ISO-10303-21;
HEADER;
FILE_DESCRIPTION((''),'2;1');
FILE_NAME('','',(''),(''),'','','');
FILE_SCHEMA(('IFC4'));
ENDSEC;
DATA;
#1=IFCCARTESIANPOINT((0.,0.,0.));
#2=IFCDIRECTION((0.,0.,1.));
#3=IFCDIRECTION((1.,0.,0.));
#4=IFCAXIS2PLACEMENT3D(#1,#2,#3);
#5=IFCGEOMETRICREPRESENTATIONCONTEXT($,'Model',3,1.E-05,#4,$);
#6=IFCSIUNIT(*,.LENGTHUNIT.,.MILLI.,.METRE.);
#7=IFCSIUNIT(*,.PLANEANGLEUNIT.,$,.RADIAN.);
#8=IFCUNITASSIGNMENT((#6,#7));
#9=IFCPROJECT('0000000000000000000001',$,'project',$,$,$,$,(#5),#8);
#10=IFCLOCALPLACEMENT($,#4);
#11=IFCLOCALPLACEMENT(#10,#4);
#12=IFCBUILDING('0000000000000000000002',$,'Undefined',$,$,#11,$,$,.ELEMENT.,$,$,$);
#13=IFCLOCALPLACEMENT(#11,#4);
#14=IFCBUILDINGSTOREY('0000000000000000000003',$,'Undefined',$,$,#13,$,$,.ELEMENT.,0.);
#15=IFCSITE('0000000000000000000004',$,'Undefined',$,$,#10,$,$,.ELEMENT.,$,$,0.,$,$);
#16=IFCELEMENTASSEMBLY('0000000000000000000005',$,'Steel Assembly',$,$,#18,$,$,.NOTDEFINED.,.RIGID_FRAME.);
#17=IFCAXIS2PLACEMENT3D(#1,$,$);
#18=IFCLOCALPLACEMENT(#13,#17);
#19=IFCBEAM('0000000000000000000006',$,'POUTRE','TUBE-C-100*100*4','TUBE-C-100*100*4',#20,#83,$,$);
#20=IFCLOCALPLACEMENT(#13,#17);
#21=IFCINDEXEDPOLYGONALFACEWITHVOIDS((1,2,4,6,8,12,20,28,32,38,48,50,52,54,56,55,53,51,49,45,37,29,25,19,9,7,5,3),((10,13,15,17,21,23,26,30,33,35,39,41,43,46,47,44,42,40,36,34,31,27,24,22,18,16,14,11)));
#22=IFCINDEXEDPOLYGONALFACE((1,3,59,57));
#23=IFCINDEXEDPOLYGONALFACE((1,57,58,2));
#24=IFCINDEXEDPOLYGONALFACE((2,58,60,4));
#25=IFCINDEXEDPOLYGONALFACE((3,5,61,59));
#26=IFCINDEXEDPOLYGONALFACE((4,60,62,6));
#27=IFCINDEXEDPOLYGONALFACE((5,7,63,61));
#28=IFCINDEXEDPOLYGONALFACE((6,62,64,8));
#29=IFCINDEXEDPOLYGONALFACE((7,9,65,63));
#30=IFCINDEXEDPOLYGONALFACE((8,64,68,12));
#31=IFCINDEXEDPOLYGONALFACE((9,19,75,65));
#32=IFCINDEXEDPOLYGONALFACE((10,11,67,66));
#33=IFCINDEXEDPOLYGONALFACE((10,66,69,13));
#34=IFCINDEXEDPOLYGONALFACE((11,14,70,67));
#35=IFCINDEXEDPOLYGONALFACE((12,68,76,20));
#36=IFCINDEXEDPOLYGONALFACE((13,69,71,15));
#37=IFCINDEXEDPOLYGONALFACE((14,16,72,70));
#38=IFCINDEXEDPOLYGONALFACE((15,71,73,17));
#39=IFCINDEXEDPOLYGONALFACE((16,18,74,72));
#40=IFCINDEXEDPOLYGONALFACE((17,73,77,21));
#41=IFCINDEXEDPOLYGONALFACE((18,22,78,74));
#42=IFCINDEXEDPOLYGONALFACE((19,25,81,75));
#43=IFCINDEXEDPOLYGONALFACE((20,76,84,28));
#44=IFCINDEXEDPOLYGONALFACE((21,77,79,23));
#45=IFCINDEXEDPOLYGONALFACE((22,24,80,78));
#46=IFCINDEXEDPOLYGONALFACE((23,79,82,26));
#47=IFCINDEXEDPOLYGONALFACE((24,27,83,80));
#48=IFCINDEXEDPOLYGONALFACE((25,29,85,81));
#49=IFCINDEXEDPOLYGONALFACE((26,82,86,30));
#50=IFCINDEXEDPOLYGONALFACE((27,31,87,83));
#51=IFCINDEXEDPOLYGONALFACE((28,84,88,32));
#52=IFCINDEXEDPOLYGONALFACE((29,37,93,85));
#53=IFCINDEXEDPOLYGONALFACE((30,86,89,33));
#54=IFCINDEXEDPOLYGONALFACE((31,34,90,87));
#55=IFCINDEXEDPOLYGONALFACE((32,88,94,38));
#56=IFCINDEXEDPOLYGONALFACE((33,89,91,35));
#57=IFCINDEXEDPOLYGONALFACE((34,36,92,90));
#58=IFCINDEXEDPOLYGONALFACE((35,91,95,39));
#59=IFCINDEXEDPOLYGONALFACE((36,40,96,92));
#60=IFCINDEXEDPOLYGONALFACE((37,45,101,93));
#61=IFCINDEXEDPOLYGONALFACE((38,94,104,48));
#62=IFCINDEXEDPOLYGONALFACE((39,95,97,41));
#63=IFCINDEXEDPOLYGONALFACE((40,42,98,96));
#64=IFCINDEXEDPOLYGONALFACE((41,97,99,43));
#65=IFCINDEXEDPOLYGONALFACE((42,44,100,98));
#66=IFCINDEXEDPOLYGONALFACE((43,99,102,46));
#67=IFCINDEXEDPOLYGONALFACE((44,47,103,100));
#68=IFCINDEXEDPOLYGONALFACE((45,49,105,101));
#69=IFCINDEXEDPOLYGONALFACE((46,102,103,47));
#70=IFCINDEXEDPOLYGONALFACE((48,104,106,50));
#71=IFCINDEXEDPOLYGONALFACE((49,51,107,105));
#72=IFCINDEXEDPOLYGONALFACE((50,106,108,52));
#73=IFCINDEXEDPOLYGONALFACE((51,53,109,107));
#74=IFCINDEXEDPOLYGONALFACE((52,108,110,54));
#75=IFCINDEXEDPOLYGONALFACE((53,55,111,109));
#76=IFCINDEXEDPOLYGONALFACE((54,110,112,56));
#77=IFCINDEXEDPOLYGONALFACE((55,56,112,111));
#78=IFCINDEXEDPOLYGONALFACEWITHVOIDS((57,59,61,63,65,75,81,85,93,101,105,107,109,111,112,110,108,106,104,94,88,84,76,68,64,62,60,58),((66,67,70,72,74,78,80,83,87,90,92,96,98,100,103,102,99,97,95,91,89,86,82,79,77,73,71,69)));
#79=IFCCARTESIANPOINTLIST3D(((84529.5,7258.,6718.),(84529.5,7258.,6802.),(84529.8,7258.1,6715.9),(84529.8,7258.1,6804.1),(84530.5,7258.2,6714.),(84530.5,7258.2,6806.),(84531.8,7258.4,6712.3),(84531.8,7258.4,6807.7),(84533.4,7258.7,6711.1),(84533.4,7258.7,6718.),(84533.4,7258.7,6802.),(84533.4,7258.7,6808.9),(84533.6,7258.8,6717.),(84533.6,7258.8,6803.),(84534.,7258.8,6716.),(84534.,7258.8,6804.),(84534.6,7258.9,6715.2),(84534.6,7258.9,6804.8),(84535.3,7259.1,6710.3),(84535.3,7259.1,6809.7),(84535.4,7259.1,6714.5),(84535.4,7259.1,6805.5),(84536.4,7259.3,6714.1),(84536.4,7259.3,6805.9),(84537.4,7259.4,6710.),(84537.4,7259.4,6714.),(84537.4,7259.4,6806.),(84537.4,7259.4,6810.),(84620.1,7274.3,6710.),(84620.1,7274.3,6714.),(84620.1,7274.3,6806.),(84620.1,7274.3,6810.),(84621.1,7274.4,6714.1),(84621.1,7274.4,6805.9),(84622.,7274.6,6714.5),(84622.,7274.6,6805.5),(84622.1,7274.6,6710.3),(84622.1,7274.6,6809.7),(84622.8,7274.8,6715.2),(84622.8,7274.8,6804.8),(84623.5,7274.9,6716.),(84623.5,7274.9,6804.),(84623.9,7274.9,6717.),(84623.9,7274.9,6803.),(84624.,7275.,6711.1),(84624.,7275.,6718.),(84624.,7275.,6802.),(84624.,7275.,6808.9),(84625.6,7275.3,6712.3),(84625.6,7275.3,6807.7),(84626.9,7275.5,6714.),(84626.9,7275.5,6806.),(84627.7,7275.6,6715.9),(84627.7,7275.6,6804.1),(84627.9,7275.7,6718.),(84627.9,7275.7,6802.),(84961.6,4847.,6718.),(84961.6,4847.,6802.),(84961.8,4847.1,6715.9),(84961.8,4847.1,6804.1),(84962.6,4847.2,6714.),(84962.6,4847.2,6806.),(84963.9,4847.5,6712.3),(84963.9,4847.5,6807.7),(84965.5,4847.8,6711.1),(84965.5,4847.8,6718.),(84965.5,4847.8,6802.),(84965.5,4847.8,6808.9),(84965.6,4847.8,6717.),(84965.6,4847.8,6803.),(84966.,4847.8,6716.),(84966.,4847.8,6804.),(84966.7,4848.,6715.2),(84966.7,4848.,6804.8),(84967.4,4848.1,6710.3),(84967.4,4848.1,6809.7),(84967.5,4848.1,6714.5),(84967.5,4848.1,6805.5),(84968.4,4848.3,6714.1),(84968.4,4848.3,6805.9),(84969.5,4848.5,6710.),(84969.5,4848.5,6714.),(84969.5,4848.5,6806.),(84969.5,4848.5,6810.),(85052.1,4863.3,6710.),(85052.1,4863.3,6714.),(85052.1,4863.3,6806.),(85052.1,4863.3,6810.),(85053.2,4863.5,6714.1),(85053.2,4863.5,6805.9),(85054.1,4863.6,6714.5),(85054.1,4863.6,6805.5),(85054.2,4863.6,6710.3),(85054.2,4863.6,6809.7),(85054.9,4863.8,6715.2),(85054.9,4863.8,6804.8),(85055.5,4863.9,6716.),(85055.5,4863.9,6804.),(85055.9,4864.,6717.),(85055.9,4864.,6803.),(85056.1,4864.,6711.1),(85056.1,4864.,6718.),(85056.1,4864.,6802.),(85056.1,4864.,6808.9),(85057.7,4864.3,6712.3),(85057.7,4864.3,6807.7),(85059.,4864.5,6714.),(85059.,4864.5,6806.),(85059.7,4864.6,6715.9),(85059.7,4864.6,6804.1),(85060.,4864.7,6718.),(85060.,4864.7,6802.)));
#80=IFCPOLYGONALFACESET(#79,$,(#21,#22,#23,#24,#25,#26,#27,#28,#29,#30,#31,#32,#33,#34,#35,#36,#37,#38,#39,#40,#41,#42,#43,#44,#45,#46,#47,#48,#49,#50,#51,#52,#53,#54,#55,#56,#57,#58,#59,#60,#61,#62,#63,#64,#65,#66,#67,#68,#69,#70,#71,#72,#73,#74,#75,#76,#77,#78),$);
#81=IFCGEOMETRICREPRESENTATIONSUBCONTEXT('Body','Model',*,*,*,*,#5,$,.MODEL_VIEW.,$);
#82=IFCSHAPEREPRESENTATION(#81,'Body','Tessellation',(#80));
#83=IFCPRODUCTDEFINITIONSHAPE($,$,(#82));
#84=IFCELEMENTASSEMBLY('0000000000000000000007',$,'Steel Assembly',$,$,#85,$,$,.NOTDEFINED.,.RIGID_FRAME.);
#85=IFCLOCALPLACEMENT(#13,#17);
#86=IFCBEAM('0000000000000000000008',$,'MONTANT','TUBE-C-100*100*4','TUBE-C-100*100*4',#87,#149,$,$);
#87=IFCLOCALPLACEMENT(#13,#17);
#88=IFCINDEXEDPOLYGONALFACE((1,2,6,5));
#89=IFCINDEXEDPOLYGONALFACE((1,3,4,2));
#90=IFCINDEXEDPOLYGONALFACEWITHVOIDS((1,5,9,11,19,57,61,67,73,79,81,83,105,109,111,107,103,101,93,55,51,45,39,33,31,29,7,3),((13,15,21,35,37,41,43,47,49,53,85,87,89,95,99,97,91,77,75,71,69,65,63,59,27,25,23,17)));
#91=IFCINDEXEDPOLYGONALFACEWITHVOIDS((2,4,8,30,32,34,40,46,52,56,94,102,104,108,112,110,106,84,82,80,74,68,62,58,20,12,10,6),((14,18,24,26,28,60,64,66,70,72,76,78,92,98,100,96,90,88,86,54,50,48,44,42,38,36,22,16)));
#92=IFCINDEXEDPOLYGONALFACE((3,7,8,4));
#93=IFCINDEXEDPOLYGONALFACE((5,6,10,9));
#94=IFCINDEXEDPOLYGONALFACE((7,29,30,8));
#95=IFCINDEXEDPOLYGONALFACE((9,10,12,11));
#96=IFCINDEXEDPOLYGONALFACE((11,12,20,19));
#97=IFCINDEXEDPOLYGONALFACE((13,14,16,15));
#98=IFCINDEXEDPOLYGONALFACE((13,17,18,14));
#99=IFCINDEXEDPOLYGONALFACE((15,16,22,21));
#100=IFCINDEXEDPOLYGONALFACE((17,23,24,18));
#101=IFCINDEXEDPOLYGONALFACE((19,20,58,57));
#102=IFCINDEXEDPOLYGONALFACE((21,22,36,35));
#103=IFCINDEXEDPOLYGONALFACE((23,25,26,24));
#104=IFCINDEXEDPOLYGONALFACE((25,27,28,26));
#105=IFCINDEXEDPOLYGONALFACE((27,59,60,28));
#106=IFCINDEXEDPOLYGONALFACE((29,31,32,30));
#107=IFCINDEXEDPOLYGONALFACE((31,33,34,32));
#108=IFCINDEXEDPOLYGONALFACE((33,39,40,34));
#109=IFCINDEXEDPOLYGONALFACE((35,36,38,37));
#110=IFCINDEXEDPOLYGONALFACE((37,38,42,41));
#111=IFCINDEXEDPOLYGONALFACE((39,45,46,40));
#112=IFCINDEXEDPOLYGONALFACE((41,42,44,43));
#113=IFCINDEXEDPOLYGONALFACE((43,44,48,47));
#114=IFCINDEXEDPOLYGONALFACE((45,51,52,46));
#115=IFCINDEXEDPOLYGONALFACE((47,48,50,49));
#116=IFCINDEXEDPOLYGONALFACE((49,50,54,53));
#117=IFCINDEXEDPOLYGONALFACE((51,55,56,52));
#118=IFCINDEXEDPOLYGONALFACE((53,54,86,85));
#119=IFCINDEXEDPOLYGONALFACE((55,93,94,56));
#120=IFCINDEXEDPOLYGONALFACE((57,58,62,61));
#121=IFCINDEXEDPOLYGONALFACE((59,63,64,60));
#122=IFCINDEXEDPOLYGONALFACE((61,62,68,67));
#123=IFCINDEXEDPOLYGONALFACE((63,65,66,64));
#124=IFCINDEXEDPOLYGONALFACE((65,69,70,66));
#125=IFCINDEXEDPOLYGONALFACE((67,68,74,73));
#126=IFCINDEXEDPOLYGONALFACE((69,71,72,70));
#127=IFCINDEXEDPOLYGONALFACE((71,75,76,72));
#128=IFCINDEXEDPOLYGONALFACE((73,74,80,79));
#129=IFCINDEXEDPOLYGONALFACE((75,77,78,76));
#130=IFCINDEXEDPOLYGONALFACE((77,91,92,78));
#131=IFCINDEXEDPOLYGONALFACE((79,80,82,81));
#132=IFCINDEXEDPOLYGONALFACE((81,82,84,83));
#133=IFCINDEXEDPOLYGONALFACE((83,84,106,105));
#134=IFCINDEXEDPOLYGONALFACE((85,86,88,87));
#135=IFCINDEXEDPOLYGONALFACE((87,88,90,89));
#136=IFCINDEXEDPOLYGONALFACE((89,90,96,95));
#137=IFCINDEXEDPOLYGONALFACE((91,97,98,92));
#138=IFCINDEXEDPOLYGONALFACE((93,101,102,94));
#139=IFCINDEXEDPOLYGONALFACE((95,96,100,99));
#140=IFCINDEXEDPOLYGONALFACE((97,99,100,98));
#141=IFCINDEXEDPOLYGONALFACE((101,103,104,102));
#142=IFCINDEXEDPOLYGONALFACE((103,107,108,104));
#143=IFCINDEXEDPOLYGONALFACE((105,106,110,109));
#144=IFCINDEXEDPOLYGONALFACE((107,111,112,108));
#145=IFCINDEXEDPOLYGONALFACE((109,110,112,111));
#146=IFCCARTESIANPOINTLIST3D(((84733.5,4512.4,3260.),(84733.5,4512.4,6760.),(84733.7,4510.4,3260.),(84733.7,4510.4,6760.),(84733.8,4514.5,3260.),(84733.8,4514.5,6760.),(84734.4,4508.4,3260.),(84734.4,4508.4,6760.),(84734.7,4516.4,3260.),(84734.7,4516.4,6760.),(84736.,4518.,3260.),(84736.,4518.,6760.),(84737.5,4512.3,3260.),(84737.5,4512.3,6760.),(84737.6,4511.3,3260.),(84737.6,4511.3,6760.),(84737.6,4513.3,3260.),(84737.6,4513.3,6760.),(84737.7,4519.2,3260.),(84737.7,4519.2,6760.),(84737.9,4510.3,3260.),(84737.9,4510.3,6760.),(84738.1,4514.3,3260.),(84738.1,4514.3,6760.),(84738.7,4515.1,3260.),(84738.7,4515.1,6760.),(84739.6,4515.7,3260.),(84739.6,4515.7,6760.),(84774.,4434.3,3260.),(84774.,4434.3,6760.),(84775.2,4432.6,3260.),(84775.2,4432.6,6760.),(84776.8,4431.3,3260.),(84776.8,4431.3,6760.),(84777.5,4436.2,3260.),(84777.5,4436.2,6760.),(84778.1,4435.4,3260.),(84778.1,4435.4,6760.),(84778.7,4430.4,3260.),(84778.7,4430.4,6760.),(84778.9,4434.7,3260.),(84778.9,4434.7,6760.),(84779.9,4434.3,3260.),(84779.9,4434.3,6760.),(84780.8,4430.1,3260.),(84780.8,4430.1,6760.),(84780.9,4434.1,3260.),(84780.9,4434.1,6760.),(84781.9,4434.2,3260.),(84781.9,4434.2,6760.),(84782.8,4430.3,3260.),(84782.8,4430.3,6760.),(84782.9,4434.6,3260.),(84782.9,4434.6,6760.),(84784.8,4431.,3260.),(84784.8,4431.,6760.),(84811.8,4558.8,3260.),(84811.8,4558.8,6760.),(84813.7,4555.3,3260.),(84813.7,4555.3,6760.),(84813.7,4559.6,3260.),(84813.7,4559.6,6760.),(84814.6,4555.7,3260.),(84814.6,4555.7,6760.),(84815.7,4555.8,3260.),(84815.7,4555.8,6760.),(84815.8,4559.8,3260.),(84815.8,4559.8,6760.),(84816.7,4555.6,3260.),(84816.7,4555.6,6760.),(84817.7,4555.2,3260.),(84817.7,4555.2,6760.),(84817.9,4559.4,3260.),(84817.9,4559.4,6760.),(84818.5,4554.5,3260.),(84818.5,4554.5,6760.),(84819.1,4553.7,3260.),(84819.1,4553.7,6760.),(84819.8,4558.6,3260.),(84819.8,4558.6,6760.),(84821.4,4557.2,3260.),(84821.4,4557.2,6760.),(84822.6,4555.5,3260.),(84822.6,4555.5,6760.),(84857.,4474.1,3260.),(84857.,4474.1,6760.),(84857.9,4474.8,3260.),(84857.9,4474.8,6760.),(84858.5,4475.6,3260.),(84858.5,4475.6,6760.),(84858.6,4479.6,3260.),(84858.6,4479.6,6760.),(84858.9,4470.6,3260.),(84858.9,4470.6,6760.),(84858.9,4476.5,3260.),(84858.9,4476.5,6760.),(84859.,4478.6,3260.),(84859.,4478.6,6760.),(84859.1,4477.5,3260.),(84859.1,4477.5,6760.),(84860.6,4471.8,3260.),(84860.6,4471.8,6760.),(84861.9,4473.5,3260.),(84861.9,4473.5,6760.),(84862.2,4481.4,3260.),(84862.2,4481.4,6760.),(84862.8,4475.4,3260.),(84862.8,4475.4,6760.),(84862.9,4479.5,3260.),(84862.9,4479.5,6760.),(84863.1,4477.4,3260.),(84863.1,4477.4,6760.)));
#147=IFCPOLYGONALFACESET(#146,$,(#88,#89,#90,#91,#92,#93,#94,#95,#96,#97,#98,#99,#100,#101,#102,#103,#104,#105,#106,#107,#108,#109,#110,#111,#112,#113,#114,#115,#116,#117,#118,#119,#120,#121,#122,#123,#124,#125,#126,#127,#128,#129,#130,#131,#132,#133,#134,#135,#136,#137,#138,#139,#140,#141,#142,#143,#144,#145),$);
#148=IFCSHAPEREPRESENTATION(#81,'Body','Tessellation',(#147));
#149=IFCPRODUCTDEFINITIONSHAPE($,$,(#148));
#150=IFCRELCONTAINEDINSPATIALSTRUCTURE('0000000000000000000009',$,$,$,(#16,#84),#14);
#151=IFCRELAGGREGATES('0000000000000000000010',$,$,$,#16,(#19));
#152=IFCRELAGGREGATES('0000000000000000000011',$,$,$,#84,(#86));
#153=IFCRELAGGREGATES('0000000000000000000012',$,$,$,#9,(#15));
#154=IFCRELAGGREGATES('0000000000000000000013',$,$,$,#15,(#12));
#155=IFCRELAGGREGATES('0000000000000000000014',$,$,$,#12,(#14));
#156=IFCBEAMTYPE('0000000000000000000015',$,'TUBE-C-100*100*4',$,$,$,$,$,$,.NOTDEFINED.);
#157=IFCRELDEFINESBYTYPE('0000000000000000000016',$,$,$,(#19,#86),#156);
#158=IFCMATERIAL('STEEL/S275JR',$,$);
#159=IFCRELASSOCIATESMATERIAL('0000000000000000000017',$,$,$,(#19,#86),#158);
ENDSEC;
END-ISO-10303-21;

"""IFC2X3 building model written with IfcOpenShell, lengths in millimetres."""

from ifc_helpers import new_model, si_unit, frame, origin_with_axes, origin_2d_with_axis, place, context, subcontext, project, spatial, hollow_rectangle, extrude, material, type_object, element, aggregate, save


model = new_model("IFC2X3")

# Units and contexts
model_context = context("Model", 3, precision=1e-05, world=origin_with_axes())
body_context = subcontext(model_context, "Body", "Model", "MODEL_VIEW")
ifc_project = project(units=[si_unit("LENGTHUNIT", "METRE", prefix="MILLI"), si_unit("PLANEANGLEUNIT", "RADIAN")], contexts=[model_context])

# Site, building, storey
site_placement = place(None, origin_with_axes())
site = spatial("IfcSite", under=ifc_project, at=site_placement, Name="Undefined", CompositionType="ELEMENT", RefElevation=0.0)
building_placement = place(site_placement, origin_with_axes())
building = spatial("IfcBuilding", under=site, at=building_placement, Name="Undefined", CompositionType="ELEMENT")
storey_placement = place(building_placement, origin_with_axes())
storey = spatial("IfcBuildingStorey", under=building, at=storey_placement, Name="Undefined", CompositionType="ELEMENT", Elevation=0.0)

# Element assemblies, beams
ifc_material_1 = material(Name="STEEL/S275JR")
beam_type_1 = type_object("IfcBeamType", Name="TUBE-C-100*100*4", PredefinedType="NOTDEFINED")
assembly_1_placement = place(storey_placement, origin_with_axes())
assembly_1 = element("IfcElementAssembly", 1, at=assembly_1_placement, inside=storey, Name="Steel Assembly", AssemblyPlace="NOTDEFINED", PredefinedType="RIGID_FRAME")
beam_1_placement = place(assembly_1_placement, frame((85010.8, 4855.9, 6760.0), z_axis=(-0.984318, -0.176404, 0.0), x_axis=(-0.176404, 0.984318, 0.0)))
beam_1 = element("IfcBeam", 2, at=beam_1_placement, type_object=beam_type_1, material=ifc_material_1, Name="POUTRE", Description="TUBE-C-100*100*4", ObjectType="TUBE-C-100*100*4", context=body_context, shape_type="SweptSolid", body=[
    extrude(hollow_rectangle(XDim=100.0, YDim=100.0, WallThickness=4.0, InnerFilletRadius=4.0, OuterFilletRadius=8.0, at=origin_2d_with_axis()), frame((2449.4, 0.0, 0.0), z_axis=(-1.0, 0.0, 0.0), x_axis=(0.0, -1.0, 0.0)), (0.0, 0.0, 1.0), 2449.4),
])
aggregate(assembly_1, [beam_1])
assembly_2_placement = place(storey_placement, origin_with_axes())
assembly_2 = element("IfcElementAssembly", 3, at=assembly_2_placement, inside=storey, Name="Steel Assembly", AssemblyPlace="NOTDEFINED", PredefinedType="RIGID_FRAME")
beam_2_placement = place(assembly_2_placement, frame((84798.3, 4494.9, 6760.0), z_axis=(-0.882022, -0.471209, 0.0), x_axis=(0.0, 0.0, -1.0)))
beam_2 = element("IfcBeam", 4, at=beam_2_placement, type_object=beam_type_1, material=ifc_material_1, Name="MONTANT", Description="TUBE-C-100*100*4", ObjectType="TUBE-C-100*100*4", context=body_context, shape_type="SweptSolid", body=[
    extrude(hollow_rectangle(XDim=100.0, YDim=100.0, WallThickness=4.0, InnerFilletRadius=4.0, OuterFilletRadius=8.0, at=origin_2d_with_axis()), frame((3500.0, 0.0, 0.0), z_axis=(-1.0, 0.0, 0.0), x_axis=(0.0, -1.0, 0.0)), (0.0, 0.0, 1.0), 3500.0),
])
aggregate(assembly_2, [beam_2])

save(model, "model.ifc")
